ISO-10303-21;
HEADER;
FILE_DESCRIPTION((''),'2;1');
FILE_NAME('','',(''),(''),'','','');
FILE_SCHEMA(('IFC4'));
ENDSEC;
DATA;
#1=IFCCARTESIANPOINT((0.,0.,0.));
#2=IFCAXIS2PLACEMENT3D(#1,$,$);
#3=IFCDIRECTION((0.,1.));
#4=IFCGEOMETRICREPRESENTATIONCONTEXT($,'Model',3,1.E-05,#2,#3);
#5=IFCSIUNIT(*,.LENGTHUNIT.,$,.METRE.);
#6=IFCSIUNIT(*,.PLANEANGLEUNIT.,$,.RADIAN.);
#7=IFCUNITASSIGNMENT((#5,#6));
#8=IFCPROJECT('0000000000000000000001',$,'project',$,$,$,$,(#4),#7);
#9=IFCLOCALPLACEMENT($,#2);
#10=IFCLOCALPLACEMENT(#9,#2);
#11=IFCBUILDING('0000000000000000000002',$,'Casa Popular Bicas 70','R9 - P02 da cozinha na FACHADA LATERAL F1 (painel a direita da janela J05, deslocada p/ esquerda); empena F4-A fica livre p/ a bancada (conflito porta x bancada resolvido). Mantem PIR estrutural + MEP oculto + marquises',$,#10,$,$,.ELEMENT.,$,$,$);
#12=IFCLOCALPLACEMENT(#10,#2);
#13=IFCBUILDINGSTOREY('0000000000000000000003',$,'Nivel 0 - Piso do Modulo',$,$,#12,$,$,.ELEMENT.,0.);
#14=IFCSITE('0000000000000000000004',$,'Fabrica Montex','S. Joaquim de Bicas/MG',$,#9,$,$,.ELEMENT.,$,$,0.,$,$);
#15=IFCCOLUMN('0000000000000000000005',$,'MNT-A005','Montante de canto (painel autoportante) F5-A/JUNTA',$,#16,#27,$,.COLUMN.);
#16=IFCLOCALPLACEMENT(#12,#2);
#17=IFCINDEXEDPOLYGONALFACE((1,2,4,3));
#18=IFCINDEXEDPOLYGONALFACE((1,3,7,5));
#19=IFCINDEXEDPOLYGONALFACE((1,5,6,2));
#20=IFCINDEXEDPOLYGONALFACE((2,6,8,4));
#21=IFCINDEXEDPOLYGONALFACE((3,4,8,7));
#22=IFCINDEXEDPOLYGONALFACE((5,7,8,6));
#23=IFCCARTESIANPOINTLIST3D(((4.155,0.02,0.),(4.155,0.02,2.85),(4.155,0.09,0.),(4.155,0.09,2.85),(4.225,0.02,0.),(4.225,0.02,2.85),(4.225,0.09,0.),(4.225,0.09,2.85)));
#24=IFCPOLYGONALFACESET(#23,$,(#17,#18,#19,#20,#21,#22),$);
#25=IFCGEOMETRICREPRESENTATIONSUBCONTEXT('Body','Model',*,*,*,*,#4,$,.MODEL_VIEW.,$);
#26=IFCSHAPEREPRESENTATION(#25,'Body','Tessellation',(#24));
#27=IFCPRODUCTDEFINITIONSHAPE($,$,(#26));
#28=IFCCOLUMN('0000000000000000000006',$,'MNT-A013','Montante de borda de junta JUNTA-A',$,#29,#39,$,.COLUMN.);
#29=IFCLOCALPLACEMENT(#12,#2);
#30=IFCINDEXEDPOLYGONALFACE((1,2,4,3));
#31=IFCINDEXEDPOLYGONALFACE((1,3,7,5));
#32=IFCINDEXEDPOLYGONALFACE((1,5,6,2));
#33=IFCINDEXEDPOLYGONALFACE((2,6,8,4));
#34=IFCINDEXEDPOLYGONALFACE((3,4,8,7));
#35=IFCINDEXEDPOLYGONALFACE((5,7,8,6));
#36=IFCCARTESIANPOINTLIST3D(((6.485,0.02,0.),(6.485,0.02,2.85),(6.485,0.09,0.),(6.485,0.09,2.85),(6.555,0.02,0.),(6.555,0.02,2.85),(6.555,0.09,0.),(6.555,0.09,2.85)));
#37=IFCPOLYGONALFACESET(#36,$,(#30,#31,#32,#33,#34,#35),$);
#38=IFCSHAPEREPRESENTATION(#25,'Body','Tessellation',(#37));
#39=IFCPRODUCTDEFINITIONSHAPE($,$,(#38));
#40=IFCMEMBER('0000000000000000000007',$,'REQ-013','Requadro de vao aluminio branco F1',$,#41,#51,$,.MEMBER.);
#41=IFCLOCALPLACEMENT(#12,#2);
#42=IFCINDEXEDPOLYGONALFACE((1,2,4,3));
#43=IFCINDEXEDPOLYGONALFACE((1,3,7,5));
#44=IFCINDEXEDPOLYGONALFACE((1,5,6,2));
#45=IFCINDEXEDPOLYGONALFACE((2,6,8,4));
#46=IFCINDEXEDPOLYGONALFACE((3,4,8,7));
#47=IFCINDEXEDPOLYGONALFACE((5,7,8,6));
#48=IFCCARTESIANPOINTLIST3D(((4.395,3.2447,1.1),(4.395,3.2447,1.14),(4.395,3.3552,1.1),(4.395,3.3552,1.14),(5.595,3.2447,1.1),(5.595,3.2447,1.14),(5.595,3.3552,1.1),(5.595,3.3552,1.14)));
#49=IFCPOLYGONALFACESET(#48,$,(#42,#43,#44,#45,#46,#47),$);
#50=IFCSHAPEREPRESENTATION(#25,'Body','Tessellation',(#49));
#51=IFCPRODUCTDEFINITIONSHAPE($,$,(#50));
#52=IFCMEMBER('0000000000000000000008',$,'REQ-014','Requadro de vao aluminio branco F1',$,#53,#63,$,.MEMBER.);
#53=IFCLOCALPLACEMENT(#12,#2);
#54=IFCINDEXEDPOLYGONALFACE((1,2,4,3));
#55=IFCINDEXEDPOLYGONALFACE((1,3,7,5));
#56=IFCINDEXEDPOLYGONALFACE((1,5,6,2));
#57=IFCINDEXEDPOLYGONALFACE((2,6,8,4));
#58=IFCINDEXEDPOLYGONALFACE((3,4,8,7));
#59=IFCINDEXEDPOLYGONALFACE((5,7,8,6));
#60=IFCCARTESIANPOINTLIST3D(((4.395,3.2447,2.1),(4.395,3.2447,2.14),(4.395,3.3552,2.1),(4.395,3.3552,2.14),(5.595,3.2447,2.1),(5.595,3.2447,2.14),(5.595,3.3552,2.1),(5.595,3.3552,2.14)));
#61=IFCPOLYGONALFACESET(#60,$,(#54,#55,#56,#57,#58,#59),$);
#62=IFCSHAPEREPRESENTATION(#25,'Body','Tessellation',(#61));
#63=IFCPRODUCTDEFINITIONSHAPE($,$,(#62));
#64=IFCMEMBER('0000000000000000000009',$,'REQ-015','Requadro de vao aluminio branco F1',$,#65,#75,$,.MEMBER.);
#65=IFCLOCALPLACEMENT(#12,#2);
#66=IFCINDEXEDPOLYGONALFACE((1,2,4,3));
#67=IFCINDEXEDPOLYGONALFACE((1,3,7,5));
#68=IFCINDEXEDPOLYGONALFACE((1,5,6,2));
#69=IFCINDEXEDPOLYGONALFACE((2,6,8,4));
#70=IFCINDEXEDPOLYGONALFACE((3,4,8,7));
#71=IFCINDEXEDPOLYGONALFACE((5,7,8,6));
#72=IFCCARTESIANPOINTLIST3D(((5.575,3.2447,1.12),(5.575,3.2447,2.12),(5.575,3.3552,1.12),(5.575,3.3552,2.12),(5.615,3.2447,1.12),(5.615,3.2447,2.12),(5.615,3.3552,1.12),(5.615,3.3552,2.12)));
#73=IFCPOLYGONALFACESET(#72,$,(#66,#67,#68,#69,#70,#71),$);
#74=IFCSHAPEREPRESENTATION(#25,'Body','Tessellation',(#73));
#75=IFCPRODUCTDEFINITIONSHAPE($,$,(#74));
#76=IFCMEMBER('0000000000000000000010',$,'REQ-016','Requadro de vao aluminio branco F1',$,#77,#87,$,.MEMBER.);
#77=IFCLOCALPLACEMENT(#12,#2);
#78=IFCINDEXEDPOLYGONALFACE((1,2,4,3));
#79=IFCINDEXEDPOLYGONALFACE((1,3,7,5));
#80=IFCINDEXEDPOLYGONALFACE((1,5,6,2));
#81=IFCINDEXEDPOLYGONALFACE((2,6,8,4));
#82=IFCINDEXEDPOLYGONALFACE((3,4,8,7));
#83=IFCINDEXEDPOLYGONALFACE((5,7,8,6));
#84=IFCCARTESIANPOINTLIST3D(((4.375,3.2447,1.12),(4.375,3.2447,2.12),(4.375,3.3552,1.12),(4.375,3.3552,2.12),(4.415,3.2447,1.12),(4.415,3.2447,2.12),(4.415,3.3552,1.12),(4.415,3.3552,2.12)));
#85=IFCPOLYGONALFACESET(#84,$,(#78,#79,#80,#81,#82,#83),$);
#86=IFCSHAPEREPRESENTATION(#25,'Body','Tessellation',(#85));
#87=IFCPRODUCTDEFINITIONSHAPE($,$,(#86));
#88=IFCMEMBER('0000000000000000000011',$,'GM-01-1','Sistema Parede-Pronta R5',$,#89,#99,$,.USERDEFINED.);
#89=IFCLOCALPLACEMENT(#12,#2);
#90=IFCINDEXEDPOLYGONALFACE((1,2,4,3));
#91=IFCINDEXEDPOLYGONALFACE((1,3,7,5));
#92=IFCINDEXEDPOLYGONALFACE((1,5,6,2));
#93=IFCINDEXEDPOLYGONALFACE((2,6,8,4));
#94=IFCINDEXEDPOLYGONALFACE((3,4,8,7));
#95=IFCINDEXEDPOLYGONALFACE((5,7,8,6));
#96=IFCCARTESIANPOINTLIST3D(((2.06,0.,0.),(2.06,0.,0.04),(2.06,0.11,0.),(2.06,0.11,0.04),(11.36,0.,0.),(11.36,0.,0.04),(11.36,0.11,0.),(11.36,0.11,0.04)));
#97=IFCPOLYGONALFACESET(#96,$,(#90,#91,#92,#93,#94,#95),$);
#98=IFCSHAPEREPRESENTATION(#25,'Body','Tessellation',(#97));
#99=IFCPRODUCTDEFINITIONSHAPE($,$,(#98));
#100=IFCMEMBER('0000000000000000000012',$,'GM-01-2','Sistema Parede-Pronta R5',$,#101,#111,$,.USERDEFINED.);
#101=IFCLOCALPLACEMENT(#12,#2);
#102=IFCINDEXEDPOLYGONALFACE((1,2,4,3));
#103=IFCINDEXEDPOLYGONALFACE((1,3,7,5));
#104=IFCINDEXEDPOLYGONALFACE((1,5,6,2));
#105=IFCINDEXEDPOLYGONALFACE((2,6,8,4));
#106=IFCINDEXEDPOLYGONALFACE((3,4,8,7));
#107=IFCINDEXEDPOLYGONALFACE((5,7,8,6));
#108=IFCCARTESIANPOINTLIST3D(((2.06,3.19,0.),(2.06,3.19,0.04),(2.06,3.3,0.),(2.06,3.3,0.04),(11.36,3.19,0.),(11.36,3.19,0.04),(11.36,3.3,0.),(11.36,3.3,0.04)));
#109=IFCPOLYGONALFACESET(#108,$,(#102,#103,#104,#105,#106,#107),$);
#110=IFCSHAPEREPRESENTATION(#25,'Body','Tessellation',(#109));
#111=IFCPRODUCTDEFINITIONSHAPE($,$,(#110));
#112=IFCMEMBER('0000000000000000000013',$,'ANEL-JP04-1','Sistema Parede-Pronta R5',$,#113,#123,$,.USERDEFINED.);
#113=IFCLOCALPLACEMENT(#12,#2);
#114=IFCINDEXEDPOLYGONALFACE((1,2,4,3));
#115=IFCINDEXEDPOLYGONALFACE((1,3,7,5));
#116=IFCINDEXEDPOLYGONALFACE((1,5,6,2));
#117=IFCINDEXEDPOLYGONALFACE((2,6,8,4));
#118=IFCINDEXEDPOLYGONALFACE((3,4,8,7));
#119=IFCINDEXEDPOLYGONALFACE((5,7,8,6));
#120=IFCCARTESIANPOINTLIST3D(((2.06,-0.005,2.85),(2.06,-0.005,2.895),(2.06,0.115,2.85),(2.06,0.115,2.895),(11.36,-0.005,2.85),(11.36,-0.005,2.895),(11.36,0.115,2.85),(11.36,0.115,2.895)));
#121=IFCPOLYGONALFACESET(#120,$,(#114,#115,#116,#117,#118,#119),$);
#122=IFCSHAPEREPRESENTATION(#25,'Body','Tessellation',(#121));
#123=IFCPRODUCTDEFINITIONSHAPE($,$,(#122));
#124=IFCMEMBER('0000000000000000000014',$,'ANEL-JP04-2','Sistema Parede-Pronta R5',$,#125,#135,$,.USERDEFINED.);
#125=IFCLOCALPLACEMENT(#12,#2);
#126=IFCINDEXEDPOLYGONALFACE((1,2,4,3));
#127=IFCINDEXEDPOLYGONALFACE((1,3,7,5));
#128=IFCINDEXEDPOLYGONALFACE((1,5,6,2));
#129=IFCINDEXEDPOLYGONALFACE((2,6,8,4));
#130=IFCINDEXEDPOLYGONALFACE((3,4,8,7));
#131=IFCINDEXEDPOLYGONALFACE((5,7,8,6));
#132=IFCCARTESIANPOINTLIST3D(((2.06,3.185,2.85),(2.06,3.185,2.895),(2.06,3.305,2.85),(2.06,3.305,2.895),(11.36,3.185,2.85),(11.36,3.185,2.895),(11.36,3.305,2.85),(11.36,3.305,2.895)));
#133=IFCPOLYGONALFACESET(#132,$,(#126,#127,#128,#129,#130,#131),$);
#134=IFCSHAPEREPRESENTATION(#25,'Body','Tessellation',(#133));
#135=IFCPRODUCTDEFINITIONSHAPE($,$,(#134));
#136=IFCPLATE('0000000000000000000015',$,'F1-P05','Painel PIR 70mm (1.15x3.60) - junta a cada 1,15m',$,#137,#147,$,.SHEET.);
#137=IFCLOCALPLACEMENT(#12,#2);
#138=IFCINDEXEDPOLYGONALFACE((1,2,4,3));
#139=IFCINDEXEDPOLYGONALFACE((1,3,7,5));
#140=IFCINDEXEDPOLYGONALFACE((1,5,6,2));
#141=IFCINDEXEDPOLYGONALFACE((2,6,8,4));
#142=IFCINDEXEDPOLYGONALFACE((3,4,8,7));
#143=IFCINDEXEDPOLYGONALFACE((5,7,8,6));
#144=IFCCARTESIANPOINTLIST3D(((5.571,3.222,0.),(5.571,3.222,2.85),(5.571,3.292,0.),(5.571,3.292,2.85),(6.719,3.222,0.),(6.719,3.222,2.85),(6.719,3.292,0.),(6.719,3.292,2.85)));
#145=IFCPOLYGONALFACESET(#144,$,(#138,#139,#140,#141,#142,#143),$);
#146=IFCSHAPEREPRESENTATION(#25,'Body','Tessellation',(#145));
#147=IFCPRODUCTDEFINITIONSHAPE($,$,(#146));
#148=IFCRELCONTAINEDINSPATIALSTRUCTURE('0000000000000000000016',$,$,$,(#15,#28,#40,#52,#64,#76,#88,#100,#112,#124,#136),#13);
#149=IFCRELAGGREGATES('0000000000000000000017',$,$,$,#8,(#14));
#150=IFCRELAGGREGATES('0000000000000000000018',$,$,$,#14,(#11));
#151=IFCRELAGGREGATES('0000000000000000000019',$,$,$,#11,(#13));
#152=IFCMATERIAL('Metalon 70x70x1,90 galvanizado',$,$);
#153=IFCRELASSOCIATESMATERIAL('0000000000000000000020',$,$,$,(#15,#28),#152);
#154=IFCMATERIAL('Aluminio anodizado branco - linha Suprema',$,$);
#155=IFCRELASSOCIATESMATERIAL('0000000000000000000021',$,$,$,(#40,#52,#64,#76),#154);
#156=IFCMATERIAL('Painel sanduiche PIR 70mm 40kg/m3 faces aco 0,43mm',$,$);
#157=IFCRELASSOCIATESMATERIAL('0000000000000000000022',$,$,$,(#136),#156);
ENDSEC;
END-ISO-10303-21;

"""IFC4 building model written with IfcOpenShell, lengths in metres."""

from ifc_helpers import new_model, si_unit, direction, frame, frame_2d, origin, origin_2d, place, context, subcontext, project, spatial, rectangle, extrude, material, element, save


model = new_model("IFC4")

# Units and contexts
model_context = context("Model", 3, precision=1e-05, world=origin(), true_north=direction((0.0, 1.0)))
body_context = subcontext(model_context, "Body", "Model", "MODEL_VIEW")
ifc_project = project(units=[si_unit("LENGTHUNIT", "METRE"), si_unit("PLANEANGLEUNIT", "RADIAN")], contexts=[model_context])

# Site, building, storey
site_placement = place(None, origin())
site = spatial("IfcSite", under=ifc_project, at=site_placement, Name="Fabrica Montex", Description="S. Joaquim de Bicas/MG", CompositionType="ELEMENT", RefElevation=0.0)
building_placement = place(site_placement, origin())
building = spatial("IfcBuilding", under=site, at=building_placement, Name="Casa Popular Bicas 70", Description="R9 - P02 da cozinha na FACHADA LATERAL F1 (painel a direita da janela J05, deslocada p/ esquerda); empena F4-A fica livre p/ a bancada (conflito porta x bancada resolvido). Mantem PIR estrutural + MEP oculto + marquises", CompositionType="ELEMENT")
storey_placement = place(building_placement, origin())
storey = spatial("IfcBuildingStorey", under=building, at=storey_placement, Name="Nivel 0 - Piso do Modulo", CompositionType="ELEMENT", Elevation=0.0)

# Columns
ifc_material_1 = material(Name="Metalon 70x70x1,90 galvanizado")
for number, where, z_axis, x_axis, name, description in (
    (1, (4.19, 0.055, 0.0), (0.0, 0.0, 1.0), (-1.0, 0.0, 0.0), "MNT-A005", "Montante de canto (painel autoportante) F5-A/JUNTA"),
    (2, (6.52, 0.055, 0.0), (0.0, 0.0, 1.0), (-1.0, 0.0, 0.0), "MNT-A013", "Montante de borda de junta JUNTA-A"),
):
    element("IfcColumn", number, at=place(None, frame(where, z_axis=z_axis, x_axis=x_axis)), inside=storey, material=ifc_material_1, Name=name, Description=description, PredefinedType="COLUMN", context=body_context, shape_type="SweptSolid", body=[
        extrude(rectangle(XDim=0.07, YDim=0.07, at=origin_2d()), origin(), (0.0, 0.0, 1.0), 2.85),
    ])

# Members
ifc_material_2 = material(Name="Aluminio anodizado branco - linha Suprema")
for number, where, z_axis, x_axis, name in (
    (3, (5.595, 3.3, 1.12), (-1.0, 0.0, 0.0), (0.0, 0.0, 1.0), "REQ-013"),
    (4, (5.595, 3.3, 2.12), (-1.0, 0.0, 0.0), (0.0, 0.0, 1.0), "REQ-014"),
):
    element("IfcMember", number, at=place(None, frame(where, z_axis=z_axis, x_axis=x_axis)), inside=storey, material=ifc_material_2, Name=name, Description="Requadro de vao aluminio branco F1", PredefinedType="MEMBER", context=body_context, shape_type="SweptSolid", body=[
        extrude(rectangle(XDim=0.04, YDim=0.1105, at=origin_2d()), origin(), (0.0, 0.0, 1.0), 1.2),
    ])
for number, where, z_axis, x_axis, name in (
    (5, (5.595, 3.3, 1.12), (0.0, 0.0, 1.0), (-1.0, 0.0, 0.0), "REQ-015"),
    (6, (4.395, 3.3, 1.12), (0.0, 0.0, 1.0), (-1.0, 0.0, 0.0), "REQ-016"),
):
    element("IfcMember", number, at=place(None, frame(where, z_axis=z_axis, x_axis=x_axis)), inside=storey, material=ifc_material_2, Name=name, Description="Requadro de vao aluminio branco F1", PredefinedType="MEMBER", context=body_context, shape_type="SweptSolid", body=[
        extrude(rectangle(XDim=0.04, YDim=0.1105, at=origin_2d()), origin(), (0.0, 0.0, 1.0), 1.0),
    ])
for number, where, name in (
    (7, (6.71, 0.055, 0.0), "GM-01-1"),
    (8, (6.71, 3.245, 0.0), "GM-01-2"),
):
    element("IfcMember", number, at=place(storey_placement, frame(where)), inside=storey, Name=name, Description="Sistema Parede-Pronta R5", PredefinedType="USERDEFINED", context=body_context, shape_type="SweptSolid", body=[
        extrude(rectangle(XDim=9.3, YDim=0.11, at=origin_2d()), origin(), (0.0, 0.0, 1.0), 0.04),
    ])
for number, where, name in (
    (9, (6.71, 0.055, 2.85), "ANEL-JP04-1"),
    (10, (6.71, 3.245, 2.85), "ANEL-JP04-2"),
):
    element("IfcMember", number, at=place(storey_placement, frame(where)), inside=storey, Name=name, Description="Sistema Parede-Pronta R5", PredefinedType="USERDEFINED", context=body_context, shape_type="SweptSolid", body=[
        extrude(rectangle(XDim=9.3, YDim=0.12, at=origin_2d()), origin(), (0.0, 0.0, 1.0), 0.045),
    ])

# Plate
ifc_material_3 = material(Name="Painel sanduiche PIR 70mm 40kg/m3 faces aco 0,43mm")
plate_1_placement = place(None, frame((6.719, 3.257, 0.0), z_axis=(0.0, 0.0, 1.0), x_axis=(-1.0, 0.0, 0.0)))
element("IfcPlate", 11, at=plate_1_placement, inside=storey, material=ifc_material_3, Name="F1-P05", Description="Painel PIR 70mm (1.15x3.60) - junta a cada 1,15m", PredefinedType="SHEET", context=body_context, shape_type="SweptSolid", body=[
    extrude(rectangle(XDim=1.148, YDim=0.07, at=frame_2d((0.574, 0.0))), origin(), (0.0, 0.0, 1.0), 2.85),
])

save(model, "model.ifc")
